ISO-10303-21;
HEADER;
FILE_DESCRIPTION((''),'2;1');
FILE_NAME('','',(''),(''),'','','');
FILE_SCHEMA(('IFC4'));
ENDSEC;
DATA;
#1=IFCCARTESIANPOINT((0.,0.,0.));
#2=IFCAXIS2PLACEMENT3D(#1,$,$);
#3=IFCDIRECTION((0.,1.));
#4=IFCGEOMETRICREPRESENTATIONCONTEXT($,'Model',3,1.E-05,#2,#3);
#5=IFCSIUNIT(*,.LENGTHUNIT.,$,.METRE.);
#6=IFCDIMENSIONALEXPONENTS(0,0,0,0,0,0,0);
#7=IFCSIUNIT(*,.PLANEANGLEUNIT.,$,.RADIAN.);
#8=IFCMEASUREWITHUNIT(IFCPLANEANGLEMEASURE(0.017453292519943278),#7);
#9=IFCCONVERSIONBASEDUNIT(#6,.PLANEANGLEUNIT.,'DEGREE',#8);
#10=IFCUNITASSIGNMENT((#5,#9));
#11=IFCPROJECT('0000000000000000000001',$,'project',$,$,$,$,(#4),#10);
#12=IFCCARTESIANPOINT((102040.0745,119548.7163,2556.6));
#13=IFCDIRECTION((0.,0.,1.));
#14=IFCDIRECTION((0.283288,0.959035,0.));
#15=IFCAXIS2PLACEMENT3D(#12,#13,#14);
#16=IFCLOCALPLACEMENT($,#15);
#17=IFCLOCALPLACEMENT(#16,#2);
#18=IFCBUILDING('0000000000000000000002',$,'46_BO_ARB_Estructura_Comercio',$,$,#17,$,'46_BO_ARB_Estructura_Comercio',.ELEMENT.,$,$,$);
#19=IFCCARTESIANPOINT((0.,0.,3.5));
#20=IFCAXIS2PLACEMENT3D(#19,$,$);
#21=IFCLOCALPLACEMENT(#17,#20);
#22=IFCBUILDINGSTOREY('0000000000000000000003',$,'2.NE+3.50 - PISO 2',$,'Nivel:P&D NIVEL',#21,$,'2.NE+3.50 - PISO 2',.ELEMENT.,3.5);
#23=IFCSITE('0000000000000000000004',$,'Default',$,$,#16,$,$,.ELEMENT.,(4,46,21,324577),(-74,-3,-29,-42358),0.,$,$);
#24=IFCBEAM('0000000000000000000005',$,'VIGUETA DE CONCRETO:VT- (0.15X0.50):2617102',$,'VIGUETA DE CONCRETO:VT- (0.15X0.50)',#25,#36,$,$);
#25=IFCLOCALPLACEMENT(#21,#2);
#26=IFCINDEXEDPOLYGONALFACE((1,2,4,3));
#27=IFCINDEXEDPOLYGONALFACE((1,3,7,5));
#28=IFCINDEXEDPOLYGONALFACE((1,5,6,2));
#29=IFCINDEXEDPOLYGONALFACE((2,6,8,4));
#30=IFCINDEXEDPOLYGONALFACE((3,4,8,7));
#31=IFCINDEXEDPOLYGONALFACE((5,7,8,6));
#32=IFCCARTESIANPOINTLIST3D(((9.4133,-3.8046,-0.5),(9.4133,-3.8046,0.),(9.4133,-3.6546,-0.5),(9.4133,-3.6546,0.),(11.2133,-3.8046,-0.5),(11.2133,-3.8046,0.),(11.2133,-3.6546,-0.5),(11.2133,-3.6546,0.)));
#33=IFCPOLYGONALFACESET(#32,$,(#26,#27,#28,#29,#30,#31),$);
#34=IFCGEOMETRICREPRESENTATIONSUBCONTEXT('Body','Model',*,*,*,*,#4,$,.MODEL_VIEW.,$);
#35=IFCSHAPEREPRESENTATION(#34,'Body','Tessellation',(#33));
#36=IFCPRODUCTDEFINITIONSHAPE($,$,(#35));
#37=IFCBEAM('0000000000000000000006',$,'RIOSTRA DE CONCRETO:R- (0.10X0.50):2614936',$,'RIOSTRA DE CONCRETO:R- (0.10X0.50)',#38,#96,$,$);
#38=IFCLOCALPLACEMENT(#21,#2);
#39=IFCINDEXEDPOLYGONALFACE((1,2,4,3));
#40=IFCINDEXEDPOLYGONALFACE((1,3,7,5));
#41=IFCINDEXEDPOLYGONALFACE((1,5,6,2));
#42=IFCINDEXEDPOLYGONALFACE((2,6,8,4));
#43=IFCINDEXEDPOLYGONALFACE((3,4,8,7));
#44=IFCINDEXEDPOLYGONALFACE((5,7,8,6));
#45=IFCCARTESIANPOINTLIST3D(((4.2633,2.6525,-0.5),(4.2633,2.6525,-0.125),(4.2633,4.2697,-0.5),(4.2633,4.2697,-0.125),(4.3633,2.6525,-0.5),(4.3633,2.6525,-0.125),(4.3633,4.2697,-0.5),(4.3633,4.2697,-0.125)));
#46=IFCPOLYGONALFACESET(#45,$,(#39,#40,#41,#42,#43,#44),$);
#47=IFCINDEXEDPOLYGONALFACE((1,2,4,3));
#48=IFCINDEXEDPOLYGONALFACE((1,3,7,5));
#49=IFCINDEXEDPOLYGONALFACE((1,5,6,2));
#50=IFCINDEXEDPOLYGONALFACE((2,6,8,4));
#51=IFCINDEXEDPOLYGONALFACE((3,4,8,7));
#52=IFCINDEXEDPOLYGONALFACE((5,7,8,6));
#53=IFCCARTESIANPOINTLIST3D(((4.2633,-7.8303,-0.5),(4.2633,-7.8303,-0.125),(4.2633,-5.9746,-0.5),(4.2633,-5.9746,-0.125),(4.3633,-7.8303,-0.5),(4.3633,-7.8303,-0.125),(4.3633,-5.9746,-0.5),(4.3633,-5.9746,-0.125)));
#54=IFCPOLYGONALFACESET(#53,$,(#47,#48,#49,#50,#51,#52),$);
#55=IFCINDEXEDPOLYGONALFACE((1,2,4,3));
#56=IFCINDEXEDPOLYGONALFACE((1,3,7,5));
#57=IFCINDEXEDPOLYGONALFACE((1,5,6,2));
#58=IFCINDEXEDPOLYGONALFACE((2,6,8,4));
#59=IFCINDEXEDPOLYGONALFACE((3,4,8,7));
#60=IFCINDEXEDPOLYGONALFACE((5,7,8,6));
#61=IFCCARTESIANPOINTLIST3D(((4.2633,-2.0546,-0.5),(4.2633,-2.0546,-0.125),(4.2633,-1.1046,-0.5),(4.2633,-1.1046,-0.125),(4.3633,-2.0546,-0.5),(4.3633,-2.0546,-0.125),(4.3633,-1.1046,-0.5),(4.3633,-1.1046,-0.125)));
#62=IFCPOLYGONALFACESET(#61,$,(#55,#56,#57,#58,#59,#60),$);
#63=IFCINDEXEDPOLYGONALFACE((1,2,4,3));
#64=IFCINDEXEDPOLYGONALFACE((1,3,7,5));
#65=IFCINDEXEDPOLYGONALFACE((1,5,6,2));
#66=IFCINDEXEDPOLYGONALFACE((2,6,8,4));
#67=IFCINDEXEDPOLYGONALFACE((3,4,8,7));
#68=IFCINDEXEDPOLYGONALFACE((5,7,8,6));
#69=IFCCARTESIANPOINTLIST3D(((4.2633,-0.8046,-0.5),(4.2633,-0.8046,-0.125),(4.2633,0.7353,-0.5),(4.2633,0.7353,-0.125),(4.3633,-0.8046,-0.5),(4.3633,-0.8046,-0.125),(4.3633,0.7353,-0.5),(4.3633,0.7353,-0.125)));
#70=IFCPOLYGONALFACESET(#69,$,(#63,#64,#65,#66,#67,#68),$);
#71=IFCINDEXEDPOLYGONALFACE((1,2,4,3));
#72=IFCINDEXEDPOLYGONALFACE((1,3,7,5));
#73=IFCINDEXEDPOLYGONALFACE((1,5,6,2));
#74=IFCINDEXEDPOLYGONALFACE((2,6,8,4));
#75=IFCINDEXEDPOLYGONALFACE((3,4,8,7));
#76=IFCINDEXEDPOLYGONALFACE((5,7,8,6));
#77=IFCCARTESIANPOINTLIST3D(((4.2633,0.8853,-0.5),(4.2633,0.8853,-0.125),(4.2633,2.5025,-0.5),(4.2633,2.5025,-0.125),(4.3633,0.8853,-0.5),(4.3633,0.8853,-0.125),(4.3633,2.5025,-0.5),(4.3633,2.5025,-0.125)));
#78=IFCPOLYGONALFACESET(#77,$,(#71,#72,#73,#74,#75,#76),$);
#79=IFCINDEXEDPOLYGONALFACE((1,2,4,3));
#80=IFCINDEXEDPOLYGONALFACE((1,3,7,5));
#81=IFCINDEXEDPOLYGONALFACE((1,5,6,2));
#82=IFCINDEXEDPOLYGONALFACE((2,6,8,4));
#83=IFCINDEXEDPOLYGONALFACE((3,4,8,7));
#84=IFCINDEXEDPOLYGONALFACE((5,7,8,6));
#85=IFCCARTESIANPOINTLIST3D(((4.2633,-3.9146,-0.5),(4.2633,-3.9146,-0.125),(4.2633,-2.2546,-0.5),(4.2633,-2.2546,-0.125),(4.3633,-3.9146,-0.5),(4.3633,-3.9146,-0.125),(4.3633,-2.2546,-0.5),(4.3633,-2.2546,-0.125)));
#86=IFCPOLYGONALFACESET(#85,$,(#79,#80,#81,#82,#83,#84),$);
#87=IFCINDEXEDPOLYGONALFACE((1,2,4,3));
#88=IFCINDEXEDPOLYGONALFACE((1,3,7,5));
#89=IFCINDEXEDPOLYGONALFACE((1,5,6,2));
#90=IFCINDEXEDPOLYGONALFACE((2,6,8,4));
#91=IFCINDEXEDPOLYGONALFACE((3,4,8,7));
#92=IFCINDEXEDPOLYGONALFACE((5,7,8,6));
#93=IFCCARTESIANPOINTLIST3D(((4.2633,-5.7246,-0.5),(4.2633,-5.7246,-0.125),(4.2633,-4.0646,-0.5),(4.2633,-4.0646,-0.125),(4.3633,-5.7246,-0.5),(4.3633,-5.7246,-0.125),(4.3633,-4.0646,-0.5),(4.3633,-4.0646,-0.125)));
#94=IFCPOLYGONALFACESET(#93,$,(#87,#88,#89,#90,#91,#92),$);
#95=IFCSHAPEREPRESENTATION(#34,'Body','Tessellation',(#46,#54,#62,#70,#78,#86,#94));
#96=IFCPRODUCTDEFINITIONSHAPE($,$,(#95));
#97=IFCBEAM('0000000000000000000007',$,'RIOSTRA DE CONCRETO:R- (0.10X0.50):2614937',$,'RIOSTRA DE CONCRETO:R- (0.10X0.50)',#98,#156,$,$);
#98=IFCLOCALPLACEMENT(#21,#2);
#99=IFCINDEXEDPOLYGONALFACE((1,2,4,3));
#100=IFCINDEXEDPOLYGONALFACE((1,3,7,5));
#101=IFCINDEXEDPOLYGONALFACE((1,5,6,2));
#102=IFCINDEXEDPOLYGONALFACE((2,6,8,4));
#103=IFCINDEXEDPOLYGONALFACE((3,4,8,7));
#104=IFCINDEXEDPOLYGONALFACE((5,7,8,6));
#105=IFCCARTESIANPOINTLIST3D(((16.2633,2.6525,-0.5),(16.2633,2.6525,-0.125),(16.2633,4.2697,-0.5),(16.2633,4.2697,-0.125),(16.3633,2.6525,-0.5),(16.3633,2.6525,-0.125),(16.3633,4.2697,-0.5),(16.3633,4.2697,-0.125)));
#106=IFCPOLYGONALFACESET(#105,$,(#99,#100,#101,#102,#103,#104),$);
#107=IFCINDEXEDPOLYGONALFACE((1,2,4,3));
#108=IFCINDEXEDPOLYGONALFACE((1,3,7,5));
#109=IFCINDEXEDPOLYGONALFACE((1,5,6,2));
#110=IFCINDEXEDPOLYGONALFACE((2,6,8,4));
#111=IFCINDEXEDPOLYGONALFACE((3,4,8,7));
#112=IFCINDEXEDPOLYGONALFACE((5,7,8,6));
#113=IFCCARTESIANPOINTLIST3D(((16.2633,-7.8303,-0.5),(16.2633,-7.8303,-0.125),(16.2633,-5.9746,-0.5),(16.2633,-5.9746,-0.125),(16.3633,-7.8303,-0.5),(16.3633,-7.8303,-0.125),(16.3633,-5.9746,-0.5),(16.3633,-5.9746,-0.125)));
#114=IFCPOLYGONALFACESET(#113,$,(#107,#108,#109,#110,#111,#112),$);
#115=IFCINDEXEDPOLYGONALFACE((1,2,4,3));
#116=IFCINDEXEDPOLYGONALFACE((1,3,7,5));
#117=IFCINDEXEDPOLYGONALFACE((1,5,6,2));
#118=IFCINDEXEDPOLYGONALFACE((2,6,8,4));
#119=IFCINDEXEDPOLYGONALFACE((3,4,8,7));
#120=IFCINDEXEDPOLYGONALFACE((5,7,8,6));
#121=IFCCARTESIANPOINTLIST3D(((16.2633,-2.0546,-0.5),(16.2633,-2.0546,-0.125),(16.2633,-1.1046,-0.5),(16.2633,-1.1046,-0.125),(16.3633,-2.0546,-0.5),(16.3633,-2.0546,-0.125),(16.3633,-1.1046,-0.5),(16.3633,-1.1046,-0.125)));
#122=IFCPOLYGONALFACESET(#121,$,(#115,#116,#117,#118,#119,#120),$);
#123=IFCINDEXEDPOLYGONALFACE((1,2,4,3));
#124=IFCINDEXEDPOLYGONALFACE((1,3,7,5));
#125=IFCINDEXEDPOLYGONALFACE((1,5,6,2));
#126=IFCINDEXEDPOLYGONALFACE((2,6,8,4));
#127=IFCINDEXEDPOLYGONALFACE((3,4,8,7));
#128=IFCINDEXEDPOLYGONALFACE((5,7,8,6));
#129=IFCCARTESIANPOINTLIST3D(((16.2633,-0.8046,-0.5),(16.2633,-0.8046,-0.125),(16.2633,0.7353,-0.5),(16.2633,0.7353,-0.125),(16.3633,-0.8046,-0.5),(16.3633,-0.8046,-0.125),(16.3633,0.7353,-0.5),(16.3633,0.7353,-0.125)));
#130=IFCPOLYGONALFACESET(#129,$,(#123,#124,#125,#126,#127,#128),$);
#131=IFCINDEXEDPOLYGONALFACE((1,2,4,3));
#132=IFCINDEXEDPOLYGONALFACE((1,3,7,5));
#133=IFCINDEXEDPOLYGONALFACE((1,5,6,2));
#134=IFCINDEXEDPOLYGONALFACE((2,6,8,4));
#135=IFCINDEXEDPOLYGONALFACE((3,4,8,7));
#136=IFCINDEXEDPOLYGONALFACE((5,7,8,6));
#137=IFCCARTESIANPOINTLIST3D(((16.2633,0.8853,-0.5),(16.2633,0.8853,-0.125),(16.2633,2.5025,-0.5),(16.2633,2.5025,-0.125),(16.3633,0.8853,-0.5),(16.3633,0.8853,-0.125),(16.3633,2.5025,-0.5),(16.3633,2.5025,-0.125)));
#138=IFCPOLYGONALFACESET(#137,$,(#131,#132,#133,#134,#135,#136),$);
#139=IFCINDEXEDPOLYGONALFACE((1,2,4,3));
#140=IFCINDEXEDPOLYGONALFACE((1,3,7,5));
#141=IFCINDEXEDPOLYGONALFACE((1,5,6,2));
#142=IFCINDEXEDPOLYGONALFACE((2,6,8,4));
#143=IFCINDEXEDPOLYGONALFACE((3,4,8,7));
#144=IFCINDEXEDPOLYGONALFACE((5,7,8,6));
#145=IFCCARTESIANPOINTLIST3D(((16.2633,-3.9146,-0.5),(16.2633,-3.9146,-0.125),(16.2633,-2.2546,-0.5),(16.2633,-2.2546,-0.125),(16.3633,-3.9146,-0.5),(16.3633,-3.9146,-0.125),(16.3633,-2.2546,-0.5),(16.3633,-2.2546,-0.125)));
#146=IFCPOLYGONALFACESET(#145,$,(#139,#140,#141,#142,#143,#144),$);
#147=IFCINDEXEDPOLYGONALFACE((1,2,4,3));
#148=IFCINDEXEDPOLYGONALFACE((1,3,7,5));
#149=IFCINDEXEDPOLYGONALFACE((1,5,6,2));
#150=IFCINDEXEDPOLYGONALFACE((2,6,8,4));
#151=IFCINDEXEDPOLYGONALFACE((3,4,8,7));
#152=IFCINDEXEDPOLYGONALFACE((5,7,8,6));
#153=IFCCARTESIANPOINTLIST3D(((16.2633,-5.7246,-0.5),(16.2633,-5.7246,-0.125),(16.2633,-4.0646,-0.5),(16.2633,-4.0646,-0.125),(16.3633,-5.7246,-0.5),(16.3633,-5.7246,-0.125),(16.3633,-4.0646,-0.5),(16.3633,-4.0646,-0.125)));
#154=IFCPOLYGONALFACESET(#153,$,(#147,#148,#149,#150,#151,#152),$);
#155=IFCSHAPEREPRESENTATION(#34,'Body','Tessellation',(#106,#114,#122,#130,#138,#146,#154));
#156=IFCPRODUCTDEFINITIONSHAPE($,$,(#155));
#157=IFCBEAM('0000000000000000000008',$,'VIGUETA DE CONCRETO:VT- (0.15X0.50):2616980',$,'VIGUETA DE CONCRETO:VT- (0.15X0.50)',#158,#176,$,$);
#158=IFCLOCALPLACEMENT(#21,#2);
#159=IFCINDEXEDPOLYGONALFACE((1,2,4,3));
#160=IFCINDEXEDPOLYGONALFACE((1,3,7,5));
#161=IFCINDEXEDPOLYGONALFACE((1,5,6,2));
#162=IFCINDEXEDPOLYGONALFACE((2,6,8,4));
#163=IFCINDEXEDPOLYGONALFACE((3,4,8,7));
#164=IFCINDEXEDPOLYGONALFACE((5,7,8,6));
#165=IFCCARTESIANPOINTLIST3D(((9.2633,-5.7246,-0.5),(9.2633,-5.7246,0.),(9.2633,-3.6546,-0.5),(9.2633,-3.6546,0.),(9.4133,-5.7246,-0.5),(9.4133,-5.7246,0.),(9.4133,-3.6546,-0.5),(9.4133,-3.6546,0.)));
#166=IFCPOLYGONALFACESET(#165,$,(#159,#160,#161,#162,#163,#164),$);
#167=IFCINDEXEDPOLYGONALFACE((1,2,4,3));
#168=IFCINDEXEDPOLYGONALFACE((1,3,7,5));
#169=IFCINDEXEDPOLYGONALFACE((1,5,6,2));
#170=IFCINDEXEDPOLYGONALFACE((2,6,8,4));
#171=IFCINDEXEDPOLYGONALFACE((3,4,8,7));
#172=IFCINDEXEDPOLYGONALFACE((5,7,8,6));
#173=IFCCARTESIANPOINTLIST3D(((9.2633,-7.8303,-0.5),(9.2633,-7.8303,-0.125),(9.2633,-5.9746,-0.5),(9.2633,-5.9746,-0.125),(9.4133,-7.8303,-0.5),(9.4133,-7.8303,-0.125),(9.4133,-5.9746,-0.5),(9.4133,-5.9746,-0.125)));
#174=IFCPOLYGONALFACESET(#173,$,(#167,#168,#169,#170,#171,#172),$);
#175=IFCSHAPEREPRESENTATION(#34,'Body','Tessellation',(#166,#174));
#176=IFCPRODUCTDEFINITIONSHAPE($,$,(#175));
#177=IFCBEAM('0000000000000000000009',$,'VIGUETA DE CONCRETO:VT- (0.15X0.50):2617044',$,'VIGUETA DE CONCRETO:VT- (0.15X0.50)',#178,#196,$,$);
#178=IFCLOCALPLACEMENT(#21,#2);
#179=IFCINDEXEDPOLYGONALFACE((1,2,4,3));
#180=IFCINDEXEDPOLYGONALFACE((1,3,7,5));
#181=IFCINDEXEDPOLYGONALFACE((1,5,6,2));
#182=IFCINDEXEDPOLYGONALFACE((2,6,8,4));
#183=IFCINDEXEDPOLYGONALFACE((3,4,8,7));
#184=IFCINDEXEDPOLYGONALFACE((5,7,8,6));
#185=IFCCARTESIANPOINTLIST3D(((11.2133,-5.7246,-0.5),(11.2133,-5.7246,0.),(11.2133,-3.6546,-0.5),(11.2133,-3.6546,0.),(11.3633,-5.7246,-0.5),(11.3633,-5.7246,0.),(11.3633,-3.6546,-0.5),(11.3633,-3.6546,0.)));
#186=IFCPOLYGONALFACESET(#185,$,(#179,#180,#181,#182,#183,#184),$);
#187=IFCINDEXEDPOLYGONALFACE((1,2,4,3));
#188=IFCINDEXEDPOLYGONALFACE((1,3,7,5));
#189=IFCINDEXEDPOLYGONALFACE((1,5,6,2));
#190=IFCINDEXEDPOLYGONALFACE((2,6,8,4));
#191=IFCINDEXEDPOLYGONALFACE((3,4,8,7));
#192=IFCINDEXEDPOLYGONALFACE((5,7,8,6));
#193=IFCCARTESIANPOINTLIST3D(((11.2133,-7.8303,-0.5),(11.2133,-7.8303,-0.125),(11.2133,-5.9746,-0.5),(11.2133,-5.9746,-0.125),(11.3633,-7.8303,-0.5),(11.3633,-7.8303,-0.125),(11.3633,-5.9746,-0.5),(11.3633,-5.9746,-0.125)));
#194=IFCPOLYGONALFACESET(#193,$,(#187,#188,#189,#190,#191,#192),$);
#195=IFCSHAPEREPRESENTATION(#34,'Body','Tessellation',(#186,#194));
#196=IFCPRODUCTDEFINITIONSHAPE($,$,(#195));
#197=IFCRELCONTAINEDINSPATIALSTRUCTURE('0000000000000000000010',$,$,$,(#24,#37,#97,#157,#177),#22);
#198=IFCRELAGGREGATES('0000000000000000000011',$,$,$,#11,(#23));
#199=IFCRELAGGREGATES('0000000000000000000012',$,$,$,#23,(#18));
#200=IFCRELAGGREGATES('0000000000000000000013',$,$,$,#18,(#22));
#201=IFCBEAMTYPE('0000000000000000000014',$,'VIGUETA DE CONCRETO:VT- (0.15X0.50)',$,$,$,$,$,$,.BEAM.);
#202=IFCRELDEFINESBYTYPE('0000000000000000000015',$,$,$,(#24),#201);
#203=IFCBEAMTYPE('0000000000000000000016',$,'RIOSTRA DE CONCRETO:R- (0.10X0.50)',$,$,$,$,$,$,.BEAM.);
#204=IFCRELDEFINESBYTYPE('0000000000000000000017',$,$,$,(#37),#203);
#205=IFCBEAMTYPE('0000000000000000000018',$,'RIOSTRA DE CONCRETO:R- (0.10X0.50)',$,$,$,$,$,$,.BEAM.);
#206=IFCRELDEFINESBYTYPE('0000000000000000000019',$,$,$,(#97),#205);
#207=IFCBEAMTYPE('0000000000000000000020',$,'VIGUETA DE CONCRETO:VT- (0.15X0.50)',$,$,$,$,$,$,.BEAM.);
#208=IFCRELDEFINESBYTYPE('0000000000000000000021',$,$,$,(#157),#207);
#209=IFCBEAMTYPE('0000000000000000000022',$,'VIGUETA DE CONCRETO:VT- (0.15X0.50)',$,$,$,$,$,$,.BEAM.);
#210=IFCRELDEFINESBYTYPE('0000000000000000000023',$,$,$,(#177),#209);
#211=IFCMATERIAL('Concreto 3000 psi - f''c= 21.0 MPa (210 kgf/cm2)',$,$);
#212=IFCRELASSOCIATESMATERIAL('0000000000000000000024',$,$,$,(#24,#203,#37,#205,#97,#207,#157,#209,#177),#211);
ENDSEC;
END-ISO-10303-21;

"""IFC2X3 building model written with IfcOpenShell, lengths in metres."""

from ifc_helpers import new_model, entity, si_unit, converted_unit, direction, frame, frame_2d, origin, origin_2d_with_axis, place, context, subcontext, project, spatial, rectangle, extrude, source, transform, mapped, material, type_object, type_shapes, element, save


model = new_model("IFC2X3")

# Units and contexts
model_context = context("Model", 3, precision=1e-05, world=origin(), true_north=direction((0.0, 1.0)))
body_context = subcontext(model_context, "Body", "Model", "MODEL_VIEW")
ifc_project = project(units=[si_unit("LENGTHUNIT", "METRE"), converted_unit("PLANEANGLEUNIT", "DEGREE", entity("IfcPlaneAngleMeasure", 0.017453292519943278), si_unit("PLANEANGLEUNIT", "RADIAN"), dimensions=[0, 0, 0, 0, 0, 0, 0])], contexts=[model_context])

# Site, building, storey
site_placement = place(None, frame((102040.0745, 119548.7163, 2556.6), z_axis=(0.0, 0.0, 1.0), x_axis=(0.283288, 0.959035, 0.0)))
site = spatial("IfcSite", under=ifc_project, at=site_placement, Name="Default", CompositionType="ELEMENT", RefLatitude=(4, 46, 21, 324577), RefLongitude=(-74, -3, -29, -42358), RefElevation=0.0)
building_placement = place(site_placement, origin())
building = spatial("IfcBuilding", under=site, at=building_placement, Name="46_BO_ARB_Estructura_Comercio", LongName="46_BO_ARB_Estructura_Comercio", CompositionType="ELEMENT")
storey_placement = place(building_placement, frame((0.0, 0.0, 3.5)))
storey = spatial("IfcBuildingStorey", under=building, at=storey_placement, Name="2.NE+3.50 - PISO 2", ObjectType="Nivel:P&D NIVEL", LongName="2.NE+3.50 - PISO 2", CompositionType="ELEMENT", Elevation=3.5)

# Beams
ifc_material = material(Name="Concreto 3000 psi - f'c= 21.0 MPa (210 kgf/cm2)")
beam_type_1 = type_object("IfcBeamType", Name="VIGUETA DE CONCRETO:VT- (0.15X0.50)", PredefinedType="BEAM")
beam_1_placement = place(storey_placement, frame((11.2883, -3.7296, 0.0), z_axis=(0.0, 0.0, 1.0), x_axis=(-1.0, 0.0, 0.0)))
element("IfcBeam", 1, at=beam_1_placement, inside=storey, type_object=beam_type_1, material=ifc_material, Name="VIGUETA DE CONCRETO:VT- (0.15X0.50):2617102", ObjectType="VIGUETA DE CONCRETO:VT- (0.15X0.50)", context=body_context, shape_type="SweptSolid", body=[
    extrude(rectangle(XDim=0.5, YDim=0.15, at=origin_2d_with_axis()), frame((0.075, 0.0, -0.25), z_axis=(1.0, 0.0, 0.0), x_axis=(0.0, 0.0, -1.0)), (0.0, 0.0, 1.0), 1.8),
])
beam_type_2 = type_object("IfcBeamType", Name="RIOSTRA DE CONCRETO:R- (0.10X0.50)", PredefinedType="BEAM", material=ifc_material)
shared_shape_1 = source(origin(), body_context, "Body", "SweptSolid", [
    extrude(rectangle(XDim=0.375, YDim=0.1, at=frame_2d((0.0, 0.0), x_axis=(0.0, 1.0))), frame((4.3133, 2.6525, 3.1875), z_axis=(0.0, 1.0, 0.0), x_axis=(-1.0, 0.0, 0.0)), (0.0, 0.0, 1.0), 1.6172),
    extrude(rectangle(XDim=0.375, YDim=0.1, at=frame_2d((0.0, 0.0), x_axis=(0.0, 1.0))), frame((4.3133, -7.8303, 3.1875), z_axis=(0.0, 1.0, 0.0), x_axis=(-1.0, 0.0, 0.0)), (0.0, 0.0, 1.0), 1.8557),
    extrude(rectangle(XDim=0.375, YDim=0.1, at=frame_2d((0.0, 0.0), x_axis=(0.0, 1.0))), frame((4.3133, -2.0546, 3.1875), z_axis=(0.0, 1.0, 0.0), x_axis=(-1.0, 0.0, 0.0)), (0.0, 0.0, 1.0), 0.95),
    extrude(rectangle(XDim=0.375, YDim=0.1, at=frame_2d((0.0, 0.0), x_axis=(0.0, 1.0))), frame((4.3133, -0.8046, 3.1875), z_axis=(0.0, 1.0, 0.0), x_axis=(-1.0, 0.0, 0.0)), (0.0, 0.0, 1.0), 1.5399),
    extrude(rectangle(XDim=0.375, YDim=0.1, at=frame_2d((0.0, 0.0), x_axis=(0.0, 1.0))), frame((4.3133, 0.8853, 3.1875), z_axis=(0.0, 1.0, 0.0), x_axis=(-1.0, 0.0, 0.0)), (0.0, 0.0, 1.0), 1.6172),
    extrude(rectangle(XDim=0.375, YDim=0.1, at=frame_2d((0.0, 0.0), x_axis=(0.0, 1.0))), frame((4.3133, -3.9146, 3.1875), z_axis=(0.0, 1.0, 0.0), x_axis=(-1.0, 0.0, 0.0)), (0.0, 0.0, 1.0), 1.66),
    extrude(rectangle(XDim=0.375, YDim=0.1, at=frame_2d((0.0, 0.0), x_axis=(0.0, 1.0))), frame((4.3133, -5.7246, 3.1875), z_axis=(0.0, 1.0, 0.0), x_axis=(-1.0, 0.0, 0.0)), (0.0, 0.0, 1.0), 1.66),
])
type_shapes(beam_type_2, [shared_shape_1])
beam_2_placement = place(storey_placement, frame((0.0, 0.0, -3.5)))
element("IfcBeam", 2, at=beam_2_placement, inside=storey, type_object=beam_type_2, material=ifc_material, Name="RIOSTRA DE CONCRETO:R- (0.10X0.50):2614936", ObjectType="RIOSTRA DE CONCRETO:R- (0.10X0.50)", context=body_context, shape_type="MappedRepresentation", body=[
    mapped(shared_shape_1, transform((0.0, 0.0, 0.0), scale=1.0)),
])
beam_type_3 = type_object("IfcBeamType", Name="RIOSTRA DE CONCRETO:R- (0.10X0.50)", PredefinedType="BEAM", material=ifc_material)
shared_shape_2 = source(origin(), body_context, "Body", "SweptSolid", [
    extrude(rectangle(XDim=0.375, YDim=0.1, at=frame_2d((0.0, 0.0), x_axis=(0.0, 1.0))), frame((16.3133, 2.6525, 3.1875), z_axis=(0.0, 1.0, 0.0), x_axis=(-1.0, 0.0, 0.0)), (0.0, 0.0, 1.0), 1.6172),
    extrude(rectangle(XDim=0.375, YDim=0.1, at=frame_2d((0.0, 0.0), x_axis=(0.0, 1.0))), frame((16.3133, -7.8303, 3.1875), z_axis=(0.0, 1.0, 0.0), x_axis=(-1.0, 0.0, 0.0)), (0.0, 0.0, 1.0), 1.8557),
    extrude(rectangle(XDim=0.375, YDim=0.1, at=frame_2d((0.0, 0.0), x_axis=(0.0, 1.0))), frame((16.3133, -2.0546, 3.1875), z_axis=(0.0, 1.0, 0.0), x_axis=(-1.0, 0.0, 0.0)), (0.0, 0.0, 1.0), 0.95),
    extrude(rectangle(XDim=0.375, YDim=0.1, at=frame_2d((0.0, 0.0), x_axis=(0.0, 1.0))), frame((16.3133, -0.8046, 3.1875), z_axis=(0.0, 1.0, 0.0), x_axis=(-1.0, 0.0, 0.0)), (0.0, 0.0, 1.0), 1.5399),
    extrude(rectangle(XDim=0.375, YDim=0.1, at=frame_2d((0.0, 0.0), x_axis=(0.0, 1.0))), frame((16.3133, 0.8853, 3.1875), z_axis=(0.0, 1.0, 0.0), x_axis=(-1.0, 0.0, 0.0)), (0.0, 0.0, 1.0), 1.6172),
    extrude(rectangle(XDim=0.375, YDim=0.1, at=frame_2d((0.0, 0.0), x_axis=(0.0, 1.0))), frame((16.3133, -3.9146, 3.1875), z_axis=(0.0, 1.0, 0.0), x_axis=(-1.0, 0.0, 0.0)), (0.0, 0.0, 1.0), 1.66),
    extrude(rectangle(XDim=0.375, YDim=0.1, at=frame_2d((0.0, 0.0), x_axis=(0.0, 1.0))), frame((16.3133, -5.7246, 3.1875), z_axis=(0.0, 1.0, 0.0), x_axis=(-1.0, 0.0, 0.0)), (0.0, 0.0, 1.0), 1.66),
])
type_shapes(beam_type_3, [shared_shape_2])
beam_3_placement = place(storey_placement, frame((0.0, 0.0, -3.5)))
element("IfcBeam", 3, at=beam_3_placement, inside=storey, type_object=beam_type_3, material=ifc_material, Name="RIOSTRA DE CONCRETO:R- (0.10X0.50):2614937", ObjectType="RIOSTRA DE CONCRETO:R- (0.10X0.50)", context=body_context, shape_type="MappedRepresentation", body=[
    mapped(shared_shape_2, transform((0.0, 0.0, 0.0), scale=1.0)),
])
beam_type_4 = type_object("IfcBeamType", Name="VIGUETA DE CONCRETO:VT- (0.15X0.50)", PredefinedType="BEAM", material=ifc_material)
shared_shape_3 = source(origin(), body_context, "Body", "SweptSolid", [
    extrude(rectangle(XDim=0.5, YDim=0.15, at=frame_2d((0.0, 0.0), x_axis=(0.0, 1.0))), frame((9.3383, -3.6546, 3.25), z_axis=(0.0, -1.0, 0.0), x_axis=(-1.0, 0.0, 0.0)), (0.0, 0.0, 1.0), 2.07),
    extrude(rectangle(XDim=0.375, YDim=0.15, at=frame_2d((0.0, 0.0), x_axis=(0.0, 1.0))), frame((9.3383, -5.9746, 3.1875), z_axis=(0.0, -1.0, 0.0), x_axis=(-1.0, 0.0, 0.0)), (0.0, 0.0, 1.0), 1.8557),
])
type_shapes(beam_type_4, [shared_shape_3])
beam_4_placement = place(storey_placement, frame((0.0, 0.0, -3.5)))
element("IfcBeam", 4, at=beam_4_placement, inside=storey, type_object=beam_type_4, material=ifc_material, Name="VIGUETA DE CONCRETO:VT- (0.15X0.50):2616980", ObjectType="VIGUETA DE CONCRETO:VT- (0.15X0.50)", context=body_context, shape_type="MappedRepresentation", body=[
    mapped(shared_shape_3, transform((0.0, 0.0, 0.0), scale=1.0)),
])
beam_type_5 = type_object("IfcBeamType", Name="VIGUETA DE CONCRETO:VT- (0.15X0.50)", PredefinedType="BEAM", material=ifc_material)
shared_shape_4 = source(origin(), body_context, "Body", "SweptSolid", [
    extrude(rectangle(XDim=0.5, YDim=0.15, at=frame_2d((0.0, 0.0), x_axis=(0.0, 1.0))), frame((11.2883, -3.6546, 3.25), z_axis=(0.0, -1.0, 0.0), x_axis=(-1.0, 0.0, 0.0)), (0.0, 0.0, 1.0), 2.07),
    extrude(rectangle(XDim=0.375, YDim=0.15, at=frame_2d((0.0, 0.0), x_axis=(0.0, 1.0))), frame((11.2883, -5.9746, 3.1875), z_axis=(0.0, -1.0, 0.0), x_axis=(-1.0, 0.0, 0.0)), (0.0, 0.0, 1.0), 1.8557),
])
type_shapes(beam_type_5, [shared_shape_4])
beam_5_placement = place(storey_placement, frame((0.0, 0.0, -3.5)))
element("IfcBeam", 5, at=beam_5_placement, inside=storey, type_object=beam_type_5, material=ifc_material, Name="VIGUETA DE CONCRETO:VT- (0.15X0.50):2617044", ObjectType="VIGUETA DE CONCRETO:VT- (0.15X0.50)", context=body_context, shape_type="MappedRepresentation", body=[
    mapped(shared_shape_4, transform((0.0, 0.0, 0.0), scale=1.0)),
])

save(model, "model.ifc")
